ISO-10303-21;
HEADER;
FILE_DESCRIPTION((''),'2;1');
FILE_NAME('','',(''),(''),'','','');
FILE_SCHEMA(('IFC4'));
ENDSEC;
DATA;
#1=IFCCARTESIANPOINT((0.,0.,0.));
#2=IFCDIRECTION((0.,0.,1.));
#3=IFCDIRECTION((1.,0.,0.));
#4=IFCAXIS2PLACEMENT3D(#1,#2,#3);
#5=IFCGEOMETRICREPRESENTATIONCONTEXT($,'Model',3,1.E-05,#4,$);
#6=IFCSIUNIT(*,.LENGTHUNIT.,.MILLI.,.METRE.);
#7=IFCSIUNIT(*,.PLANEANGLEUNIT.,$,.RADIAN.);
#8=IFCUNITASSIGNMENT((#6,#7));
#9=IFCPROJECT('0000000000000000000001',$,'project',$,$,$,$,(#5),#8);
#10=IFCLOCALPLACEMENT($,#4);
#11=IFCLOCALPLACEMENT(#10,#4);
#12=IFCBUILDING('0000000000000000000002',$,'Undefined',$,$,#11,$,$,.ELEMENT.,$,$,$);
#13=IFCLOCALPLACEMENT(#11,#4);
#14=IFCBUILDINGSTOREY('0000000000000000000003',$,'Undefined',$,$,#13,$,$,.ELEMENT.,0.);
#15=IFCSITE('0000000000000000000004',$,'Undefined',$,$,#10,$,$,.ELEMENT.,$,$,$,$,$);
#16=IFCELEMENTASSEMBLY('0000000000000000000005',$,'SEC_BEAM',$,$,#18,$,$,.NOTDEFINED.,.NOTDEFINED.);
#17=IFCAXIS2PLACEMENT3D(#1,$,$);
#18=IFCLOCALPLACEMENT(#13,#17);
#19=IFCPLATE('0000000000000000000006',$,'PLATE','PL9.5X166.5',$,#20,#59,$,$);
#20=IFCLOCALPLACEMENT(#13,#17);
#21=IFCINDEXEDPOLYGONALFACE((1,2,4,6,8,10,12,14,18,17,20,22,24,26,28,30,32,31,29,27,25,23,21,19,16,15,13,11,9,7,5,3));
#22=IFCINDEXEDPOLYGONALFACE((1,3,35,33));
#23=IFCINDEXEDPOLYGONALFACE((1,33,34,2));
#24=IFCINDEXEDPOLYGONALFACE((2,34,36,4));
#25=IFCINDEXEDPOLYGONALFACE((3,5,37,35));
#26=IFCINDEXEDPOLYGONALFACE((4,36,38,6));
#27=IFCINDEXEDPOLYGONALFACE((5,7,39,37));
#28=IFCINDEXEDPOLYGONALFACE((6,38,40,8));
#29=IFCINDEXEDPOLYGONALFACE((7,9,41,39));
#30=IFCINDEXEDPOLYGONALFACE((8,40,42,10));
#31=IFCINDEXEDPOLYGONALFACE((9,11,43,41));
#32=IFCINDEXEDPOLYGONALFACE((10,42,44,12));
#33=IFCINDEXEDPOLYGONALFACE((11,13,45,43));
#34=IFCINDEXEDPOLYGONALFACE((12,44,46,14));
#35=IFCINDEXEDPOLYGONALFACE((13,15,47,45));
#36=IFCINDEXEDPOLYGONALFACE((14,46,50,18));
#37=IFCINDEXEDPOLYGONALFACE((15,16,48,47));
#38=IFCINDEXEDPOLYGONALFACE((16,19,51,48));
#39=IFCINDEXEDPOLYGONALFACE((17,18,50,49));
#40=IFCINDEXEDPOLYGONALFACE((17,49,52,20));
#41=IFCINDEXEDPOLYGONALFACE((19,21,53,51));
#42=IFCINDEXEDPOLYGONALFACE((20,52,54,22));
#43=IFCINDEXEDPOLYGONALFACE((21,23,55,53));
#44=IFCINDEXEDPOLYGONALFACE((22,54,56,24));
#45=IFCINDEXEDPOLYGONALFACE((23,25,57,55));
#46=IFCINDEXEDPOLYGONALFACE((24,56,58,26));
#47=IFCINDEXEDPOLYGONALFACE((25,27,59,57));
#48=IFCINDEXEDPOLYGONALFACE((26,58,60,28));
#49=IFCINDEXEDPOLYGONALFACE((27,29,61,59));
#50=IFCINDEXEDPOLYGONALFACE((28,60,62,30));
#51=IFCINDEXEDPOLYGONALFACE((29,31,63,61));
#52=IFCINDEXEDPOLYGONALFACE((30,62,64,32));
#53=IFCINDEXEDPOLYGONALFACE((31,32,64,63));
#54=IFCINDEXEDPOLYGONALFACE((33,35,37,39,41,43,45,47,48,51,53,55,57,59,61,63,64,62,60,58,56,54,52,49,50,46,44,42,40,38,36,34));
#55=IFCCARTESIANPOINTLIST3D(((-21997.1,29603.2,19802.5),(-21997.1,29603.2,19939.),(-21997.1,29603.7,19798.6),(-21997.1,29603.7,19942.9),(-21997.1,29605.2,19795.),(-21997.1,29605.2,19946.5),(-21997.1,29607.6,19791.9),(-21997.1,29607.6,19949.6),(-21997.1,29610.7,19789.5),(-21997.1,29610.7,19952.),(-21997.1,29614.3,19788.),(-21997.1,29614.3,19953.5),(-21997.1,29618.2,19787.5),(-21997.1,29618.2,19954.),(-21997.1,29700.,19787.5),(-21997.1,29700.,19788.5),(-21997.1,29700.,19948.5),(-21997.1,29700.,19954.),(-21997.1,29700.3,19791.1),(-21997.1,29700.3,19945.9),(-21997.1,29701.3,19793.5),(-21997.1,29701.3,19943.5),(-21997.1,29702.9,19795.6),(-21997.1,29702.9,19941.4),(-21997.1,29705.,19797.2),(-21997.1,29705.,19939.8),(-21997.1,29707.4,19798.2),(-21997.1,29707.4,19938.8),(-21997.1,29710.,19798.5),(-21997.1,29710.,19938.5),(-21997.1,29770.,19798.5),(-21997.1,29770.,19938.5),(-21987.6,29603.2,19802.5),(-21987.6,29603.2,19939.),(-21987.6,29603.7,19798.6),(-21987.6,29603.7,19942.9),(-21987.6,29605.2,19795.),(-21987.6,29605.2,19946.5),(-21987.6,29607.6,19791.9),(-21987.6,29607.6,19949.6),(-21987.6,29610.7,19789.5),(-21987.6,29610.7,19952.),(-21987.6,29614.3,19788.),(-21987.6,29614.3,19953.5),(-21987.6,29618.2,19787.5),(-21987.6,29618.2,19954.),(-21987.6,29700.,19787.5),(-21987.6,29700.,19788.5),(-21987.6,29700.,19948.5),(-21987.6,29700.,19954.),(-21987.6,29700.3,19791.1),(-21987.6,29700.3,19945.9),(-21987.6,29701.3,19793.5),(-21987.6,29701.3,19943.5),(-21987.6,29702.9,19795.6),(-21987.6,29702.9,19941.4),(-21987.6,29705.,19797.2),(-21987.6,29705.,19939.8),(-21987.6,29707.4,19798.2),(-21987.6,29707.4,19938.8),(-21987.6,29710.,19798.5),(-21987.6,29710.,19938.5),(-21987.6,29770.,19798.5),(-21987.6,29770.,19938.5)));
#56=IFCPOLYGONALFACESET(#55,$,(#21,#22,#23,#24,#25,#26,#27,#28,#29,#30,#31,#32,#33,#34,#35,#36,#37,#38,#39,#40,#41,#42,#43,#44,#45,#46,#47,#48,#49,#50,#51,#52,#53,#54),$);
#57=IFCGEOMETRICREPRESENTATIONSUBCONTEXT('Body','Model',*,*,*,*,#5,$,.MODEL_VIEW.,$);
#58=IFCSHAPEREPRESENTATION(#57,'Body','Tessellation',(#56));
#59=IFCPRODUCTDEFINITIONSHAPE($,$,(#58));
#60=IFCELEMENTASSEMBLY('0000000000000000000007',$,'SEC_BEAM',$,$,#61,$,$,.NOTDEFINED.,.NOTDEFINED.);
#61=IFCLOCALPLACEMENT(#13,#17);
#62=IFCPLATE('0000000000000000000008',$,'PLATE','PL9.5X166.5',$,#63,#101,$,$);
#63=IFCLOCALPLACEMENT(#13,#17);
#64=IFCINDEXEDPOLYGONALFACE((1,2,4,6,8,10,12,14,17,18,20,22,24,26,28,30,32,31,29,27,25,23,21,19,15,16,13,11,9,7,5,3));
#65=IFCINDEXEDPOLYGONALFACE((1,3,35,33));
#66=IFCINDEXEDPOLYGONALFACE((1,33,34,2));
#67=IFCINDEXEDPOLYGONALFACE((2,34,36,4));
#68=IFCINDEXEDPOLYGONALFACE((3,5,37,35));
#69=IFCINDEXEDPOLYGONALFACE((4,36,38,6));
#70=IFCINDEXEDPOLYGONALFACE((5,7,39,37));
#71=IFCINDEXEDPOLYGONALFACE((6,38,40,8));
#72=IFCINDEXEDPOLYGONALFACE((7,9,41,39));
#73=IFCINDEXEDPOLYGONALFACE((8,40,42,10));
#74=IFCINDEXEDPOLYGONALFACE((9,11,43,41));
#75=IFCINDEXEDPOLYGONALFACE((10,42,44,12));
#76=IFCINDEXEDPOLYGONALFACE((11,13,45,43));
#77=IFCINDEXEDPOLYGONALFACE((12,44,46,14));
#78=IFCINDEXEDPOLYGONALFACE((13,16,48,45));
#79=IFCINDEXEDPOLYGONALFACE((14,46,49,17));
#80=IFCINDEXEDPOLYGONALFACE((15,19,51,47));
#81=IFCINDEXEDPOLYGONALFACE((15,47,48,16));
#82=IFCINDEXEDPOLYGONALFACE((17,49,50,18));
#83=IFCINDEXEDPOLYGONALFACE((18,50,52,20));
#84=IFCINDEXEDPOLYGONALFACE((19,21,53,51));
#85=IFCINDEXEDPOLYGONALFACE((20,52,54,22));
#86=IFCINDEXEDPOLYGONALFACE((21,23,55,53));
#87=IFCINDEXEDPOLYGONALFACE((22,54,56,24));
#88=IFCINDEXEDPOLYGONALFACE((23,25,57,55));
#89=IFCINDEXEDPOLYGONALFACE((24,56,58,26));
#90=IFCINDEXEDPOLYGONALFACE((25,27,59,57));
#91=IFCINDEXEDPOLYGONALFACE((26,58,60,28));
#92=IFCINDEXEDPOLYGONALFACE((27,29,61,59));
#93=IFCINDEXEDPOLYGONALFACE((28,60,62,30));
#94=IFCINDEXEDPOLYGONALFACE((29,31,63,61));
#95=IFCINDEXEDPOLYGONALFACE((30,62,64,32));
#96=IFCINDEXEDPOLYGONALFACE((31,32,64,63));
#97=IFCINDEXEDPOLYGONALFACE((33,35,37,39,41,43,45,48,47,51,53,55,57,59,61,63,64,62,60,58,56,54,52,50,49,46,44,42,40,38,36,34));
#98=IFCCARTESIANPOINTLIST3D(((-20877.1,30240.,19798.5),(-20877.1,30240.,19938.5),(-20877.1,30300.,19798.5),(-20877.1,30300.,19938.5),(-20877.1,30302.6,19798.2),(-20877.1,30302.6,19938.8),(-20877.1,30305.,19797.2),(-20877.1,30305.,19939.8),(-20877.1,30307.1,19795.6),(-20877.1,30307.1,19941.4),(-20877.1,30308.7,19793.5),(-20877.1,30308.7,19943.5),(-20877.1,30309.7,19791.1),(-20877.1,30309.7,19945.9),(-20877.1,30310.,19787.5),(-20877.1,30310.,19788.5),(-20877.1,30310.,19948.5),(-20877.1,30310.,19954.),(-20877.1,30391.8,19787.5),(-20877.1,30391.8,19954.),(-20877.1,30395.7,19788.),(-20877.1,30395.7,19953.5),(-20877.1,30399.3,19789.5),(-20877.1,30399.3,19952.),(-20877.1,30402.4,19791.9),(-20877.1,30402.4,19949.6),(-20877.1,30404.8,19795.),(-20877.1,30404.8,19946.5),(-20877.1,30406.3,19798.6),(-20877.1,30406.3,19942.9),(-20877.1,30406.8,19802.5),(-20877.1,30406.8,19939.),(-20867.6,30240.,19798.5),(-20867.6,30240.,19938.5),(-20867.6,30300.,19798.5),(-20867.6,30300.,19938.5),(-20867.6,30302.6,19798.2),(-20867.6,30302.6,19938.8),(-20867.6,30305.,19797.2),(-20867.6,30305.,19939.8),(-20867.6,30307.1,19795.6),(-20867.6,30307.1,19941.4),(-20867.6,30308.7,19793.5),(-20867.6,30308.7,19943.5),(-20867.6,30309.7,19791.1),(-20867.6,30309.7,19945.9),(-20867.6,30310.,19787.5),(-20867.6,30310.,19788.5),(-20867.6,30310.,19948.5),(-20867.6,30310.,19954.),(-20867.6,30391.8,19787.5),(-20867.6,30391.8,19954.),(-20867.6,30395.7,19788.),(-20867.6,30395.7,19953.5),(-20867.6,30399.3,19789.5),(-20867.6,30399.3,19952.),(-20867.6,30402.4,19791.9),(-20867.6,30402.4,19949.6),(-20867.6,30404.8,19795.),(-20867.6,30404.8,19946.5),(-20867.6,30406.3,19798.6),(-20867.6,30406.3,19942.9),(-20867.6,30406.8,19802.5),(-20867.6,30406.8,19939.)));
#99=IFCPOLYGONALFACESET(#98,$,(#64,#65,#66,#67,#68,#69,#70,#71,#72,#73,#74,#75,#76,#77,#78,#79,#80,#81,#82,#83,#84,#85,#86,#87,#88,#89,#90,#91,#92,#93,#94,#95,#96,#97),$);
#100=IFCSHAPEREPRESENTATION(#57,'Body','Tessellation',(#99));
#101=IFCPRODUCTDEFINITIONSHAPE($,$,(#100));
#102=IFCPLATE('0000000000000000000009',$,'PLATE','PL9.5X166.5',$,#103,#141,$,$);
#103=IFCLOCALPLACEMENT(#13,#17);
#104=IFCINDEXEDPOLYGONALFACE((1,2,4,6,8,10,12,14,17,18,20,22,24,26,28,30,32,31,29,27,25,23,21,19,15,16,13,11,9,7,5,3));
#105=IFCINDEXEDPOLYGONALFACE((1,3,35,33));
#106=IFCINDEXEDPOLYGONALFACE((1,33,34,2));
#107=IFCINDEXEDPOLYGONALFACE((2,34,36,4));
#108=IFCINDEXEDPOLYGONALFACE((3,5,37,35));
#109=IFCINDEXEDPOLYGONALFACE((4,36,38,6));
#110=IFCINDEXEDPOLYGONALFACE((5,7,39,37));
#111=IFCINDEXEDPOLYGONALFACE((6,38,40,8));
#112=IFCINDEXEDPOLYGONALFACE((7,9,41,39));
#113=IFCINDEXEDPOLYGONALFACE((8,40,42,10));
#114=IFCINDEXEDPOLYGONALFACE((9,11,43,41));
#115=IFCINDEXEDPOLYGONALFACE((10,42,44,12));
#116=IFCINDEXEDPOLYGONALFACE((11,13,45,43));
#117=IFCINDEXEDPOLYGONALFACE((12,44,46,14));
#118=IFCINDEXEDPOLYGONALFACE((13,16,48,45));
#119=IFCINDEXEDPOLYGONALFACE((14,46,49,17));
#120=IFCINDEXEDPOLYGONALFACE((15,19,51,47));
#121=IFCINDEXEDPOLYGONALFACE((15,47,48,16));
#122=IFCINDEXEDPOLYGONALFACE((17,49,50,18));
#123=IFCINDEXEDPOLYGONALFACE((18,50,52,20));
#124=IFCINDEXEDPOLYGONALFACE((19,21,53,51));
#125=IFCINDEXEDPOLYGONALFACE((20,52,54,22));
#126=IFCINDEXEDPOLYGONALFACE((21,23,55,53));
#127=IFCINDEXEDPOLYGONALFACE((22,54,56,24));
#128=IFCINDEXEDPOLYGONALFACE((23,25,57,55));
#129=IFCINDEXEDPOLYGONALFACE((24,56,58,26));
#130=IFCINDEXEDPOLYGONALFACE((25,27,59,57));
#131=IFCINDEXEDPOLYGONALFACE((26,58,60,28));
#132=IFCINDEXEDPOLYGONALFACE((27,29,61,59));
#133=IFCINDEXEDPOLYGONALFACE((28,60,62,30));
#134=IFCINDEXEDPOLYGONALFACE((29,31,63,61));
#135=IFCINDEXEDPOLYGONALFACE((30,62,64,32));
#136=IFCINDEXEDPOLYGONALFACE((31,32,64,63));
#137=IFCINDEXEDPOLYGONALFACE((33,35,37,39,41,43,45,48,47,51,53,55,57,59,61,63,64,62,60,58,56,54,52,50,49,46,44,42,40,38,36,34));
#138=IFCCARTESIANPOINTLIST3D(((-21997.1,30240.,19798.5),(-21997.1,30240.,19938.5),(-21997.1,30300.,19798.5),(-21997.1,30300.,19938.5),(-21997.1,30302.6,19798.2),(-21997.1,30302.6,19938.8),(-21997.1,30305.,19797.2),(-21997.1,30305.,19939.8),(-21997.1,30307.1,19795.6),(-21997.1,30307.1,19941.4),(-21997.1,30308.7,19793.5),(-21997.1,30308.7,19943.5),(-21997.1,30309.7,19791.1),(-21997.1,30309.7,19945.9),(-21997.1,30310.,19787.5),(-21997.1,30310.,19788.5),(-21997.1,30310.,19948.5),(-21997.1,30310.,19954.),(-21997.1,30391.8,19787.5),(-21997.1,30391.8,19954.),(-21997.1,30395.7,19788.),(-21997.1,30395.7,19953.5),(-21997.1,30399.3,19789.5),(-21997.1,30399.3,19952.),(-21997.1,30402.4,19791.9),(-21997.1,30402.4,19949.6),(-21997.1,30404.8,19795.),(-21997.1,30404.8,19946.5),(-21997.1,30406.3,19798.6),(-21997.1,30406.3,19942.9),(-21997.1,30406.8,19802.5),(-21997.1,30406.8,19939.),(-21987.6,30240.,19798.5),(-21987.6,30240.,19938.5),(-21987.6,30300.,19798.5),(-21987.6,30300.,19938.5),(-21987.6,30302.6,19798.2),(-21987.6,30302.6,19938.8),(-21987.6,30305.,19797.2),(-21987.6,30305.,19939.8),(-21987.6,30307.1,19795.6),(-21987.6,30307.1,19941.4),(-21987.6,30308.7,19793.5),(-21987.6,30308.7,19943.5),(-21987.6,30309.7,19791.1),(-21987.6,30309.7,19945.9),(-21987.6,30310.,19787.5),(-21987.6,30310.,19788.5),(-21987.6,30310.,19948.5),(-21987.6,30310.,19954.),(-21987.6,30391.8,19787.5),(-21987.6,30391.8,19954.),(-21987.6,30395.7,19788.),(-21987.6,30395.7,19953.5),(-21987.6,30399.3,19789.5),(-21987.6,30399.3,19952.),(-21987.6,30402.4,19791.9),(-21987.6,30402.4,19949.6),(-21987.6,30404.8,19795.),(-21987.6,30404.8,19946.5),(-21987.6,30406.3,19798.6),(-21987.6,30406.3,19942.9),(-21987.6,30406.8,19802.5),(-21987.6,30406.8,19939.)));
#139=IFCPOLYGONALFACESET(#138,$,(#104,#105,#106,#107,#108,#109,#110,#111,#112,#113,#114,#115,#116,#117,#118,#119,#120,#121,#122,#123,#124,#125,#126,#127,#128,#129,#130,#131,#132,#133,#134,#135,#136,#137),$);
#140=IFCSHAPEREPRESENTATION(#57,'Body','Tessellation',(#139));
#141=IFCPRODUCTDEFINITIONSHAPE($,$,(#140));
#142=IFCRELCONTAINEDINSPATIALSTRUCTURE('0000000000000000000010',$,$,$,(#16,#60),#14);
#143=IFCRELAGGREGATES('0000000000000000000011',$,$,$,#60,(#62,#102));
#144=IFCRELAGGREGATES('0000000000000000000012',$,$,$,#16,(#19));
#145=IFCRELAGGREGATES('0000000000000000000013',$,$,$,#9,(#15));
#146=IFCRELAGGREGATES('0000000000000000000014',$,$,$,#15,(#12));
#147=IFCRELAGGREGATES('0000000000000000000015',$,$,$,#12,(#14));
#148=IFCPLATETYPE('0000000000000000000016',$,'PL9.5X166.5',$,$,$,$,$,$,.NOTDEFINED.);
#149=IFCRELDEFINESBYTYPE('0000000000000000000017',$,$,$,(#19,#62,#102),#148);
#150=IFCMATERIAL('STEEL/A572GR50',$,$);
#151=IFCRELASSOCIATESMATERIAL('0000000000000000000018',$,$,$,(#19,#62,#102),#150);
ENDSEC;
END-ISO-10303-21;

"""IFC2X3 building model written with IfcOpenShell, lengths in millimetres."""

from ifc_helpers import new_model, si_unit, frame, frame_2d, origin_with_axes, place, context, subcontext, project, spatial, polyline, circle_curve, parameter, trimmed, segment, composite_curve, outline, extrude, material, type_object, element, aggregate, save


model = new_model("IFC2X3")

# Units and contexts
model_context = context("Model", 3, precision=1e-05, world=origin_with_axes())
body_context = subcontext(model_context, "Body", "Model", "MODEL_VIEW")
ifc_project = project(units=[si_unit("LENGTHUNIT", "METRE", prefix="MILLI"), si_unit("PLANEANGLEUNIT", "RADIAN")], contexts=[model_context])

# Site, building, storey
site_placement = place(None, origin_with_axes())
site = spatial("IfcSite", under=ifc_project, at=site_placement, Name="Undefined", CompositionType="ELEMENT")
building_placement = place(site_placement, origin_with_axes())
building = spatial("IfcBuilding", under=site, at=building_placement, Name="Undefined", CompositionType="ELEMENT")
storey_placement = place(building_placement, origin_with_axes())
storey = spatial("IfcBuildingStorey", under=building, at=storey_placement, Name="Undefined", CompositionType="ELEMENT", Elevation=0.0)

# Shared definitions
ifc_material_1 = material(Name="STEEL/A572GR50")

# Element assemblies, plates
assembly_1_placement = place(storey_placement, origin_with_axes())
assembly_1 = element("IfcElementAssembly", 1, at=assembly_1_placement, inside=storey, Name="SEC_BEAM", AssemblyPlace="NOTDEFINED", PredefinedType="NOTDEFINED")
plate_type_1 = type_object("IfcPlateType", Name="PL9.5X166.5", PredefinedType="NOTDEFINED")
plate_1_placement = place(assembly_1_placement, frame((-21992.3, 29603.2, 19954.0), z_axis=(1.0, 0.0, 0.0), x_axis=(0.0, 0.0, -1.0)))
plate_1 = element("IfcPlate", 2, at=plate_1_placement, type_object=plate_type_1, material=ifc_material_1, Name="PLATE", Description="PL9.5X166.5", context=body_context, shape_type="SweptSolid", body=[
    extrude(outline(composite_curve([segment(trimmed(circle_curve(frame_2d((15.0, 15.0), x_axis=(-1.0, 0.0)), 15.0), [parameter(0.0)], [parameter(1.570796)], True, "PARAMETER"), True, "CONTINUOUS"), segment(polyline([(15.0, 0.0), (151.5, 0.0)]), True, "CONTINUOUS"), segment(trimmed(circle_curve(frame_2d((151.5, 15.0), x_axis=(0.0, -1.0)), 15.0), [parameter(0.0)], [parameter(1.570796)], True, "PARAMETER"), True, "CONTINUOUS"), segment(polyline([(166.5, 15.0), (166.5, 96.8), (165.5, 96.8)]), True, "CONTINUOUS"), segment(trimmed(circle_curve(frame_2d((165.5, 106.8), x_axis=(0.0, -1.0)), 10.0), [parameter(0.0)], [parameter(4.712389)], False, "PARAMETER"), True, "CONTINUOUS"), segment(polyline([(155.5, 106.8), (155.5, 166.8), (15.5, 166.8), (15.5, 106.8)]), True, "CONTINUOUS"), segment(trimmed(circle_curve(frame_2d((5.5, 106.8), x_axis=(1.0, 0.0)), 10.0), [parameter(0.0)], [parameter(4.712389)], False, "PARAMETER"), True, "CONTINUOUS"), segment(polyline([(5.5, 96.8), (0.0, 96.8), (0.0, 15.0)]), True, "CONTINUOUS")], self_intersect=True)), frame((0.0, 0.0, -4.8), z_axis=(0.0, 0.0, 1.0), x_axis=(1.0, 0.0, 0.0)), (0.0, 0.0, 1.0), 9.5),
])
assembly_2_placement = place(storey_placement, origin_with_axes())
assembly_2 = element("IfcElementAssembly", 3, at=assembly_2_placement, inside=storey, Name="SEC_BEAM", AssemblyPlace="NOTDEFINED", PredefinedType="NOTDEFINED")
plate_2_placement = place(assembly_2_placement, frame((-20872.3, 30406.8, 19954.0), z_axis=(-1.0, 0.0, 0.0), x_axis=(0.0, 0.0, -1.0)))
plate_2 = element("IfcPlate", 4, at=plate_2_placement, type_object=plate_type_1, material=ifc_material_1, Name="PLATE", Description="PL9.5X166.5", context=body_context, shape_type="SweptSolid", body=[
    extrude(outline(composite_curve([segment(trimmed(circle_curve(frame_2d((15.0, 15.0), x_axis=(-1.0, 0.0)), 15.0), [parameter(0.0)], [parameter(1.570796)], True, "PARAMETER"), True, "CONTINUOUS"), segment(polyline([(15.0, 0.0), (151.5, 0.0)]), True, "CONTINUOUS"), segment(trimmed(circle_curve(frame_2d((151.5, 15.0), x_axis=(0.0, -1.0)), 15.0), [parameter(0.0)], [parameter(1.570796)], True, "PARAMETER"), True, "CONTINUOUS"), segment(polyline([(166.5, 15.0), (166.5, 96.8), (165.5, 96.8)]), True, "CONTINUOUS"), segment(trimmed(circle_curve(frame_2d((165.5, 106.8), x_axis=(0.0, -1.0)), 10.0), [parameter(0.0)], [parameter(4.712389)], False, "PARAMETER"), True, "CONTINUOUS"), segment(polyline([(155.5, 106.8), (155.5, 166.8), (15.5, 166.8), (15.5, 106.8)]), True, "CONTINUOUS"), segment(trimmed(circle_curve(frame_2d((5.5, 106.8), x_axis=(1.0, 0.0)), 10.0), [parameter(0.0)], [parameter(4.712389)], False, "PARAMETER"), True, "CONTINUOUS"), segment(polyline([(5.5, 96.8), (0.0, 96.8), (0.0, 15.0)]), True, "CONTINUOUS")], self_intersect=True)), frame((0.0, 0.0, -4.8), z_axis=(0.0, 0.0, 1.0), x_axis=(1.0, 0.0, 0.0)), (0.0, 0.0, 1.0), 9.5),
])
plate_3_placement = place(assembly_2_placement, frame((-21992.3, 30406.8, 19954.0), z_axis=(-1.0, 0.0, 0.0), x_axis=(0.0, 0.0, -1.0)))
plate_3 = element("IfcPlate", 5, at=plate_3_placement, type_object=plate_type_1, material=ifc_material_1, Name="PLATE", Description="PL9.5X166.5", context=body_context, shape_type="SweptSolid", body=[
    extrude(outline(composite_curve([segment(trimmed(circle_curve(frame_2d((15.0, 15.0), x_axis=(-1.0, 0.0)), 15.0), [parameter(0.0)], [parameter(1.570796)], True, "PARAMETER"), True, "CONTINUOUS"), segment(polyline([(15.0, 0.0), (151.5, 0.0)]), True, "CONTINUOUS"), segment(trimmed(circle_curve(frame_2d((151.5, 15.0), x_axis=(0.0, -1.0)), 15.0), [parameter(0.0)], [parameter(1.570796)], True, "PARAMETER"), True, "CONTINUOUS"), segment(polyline([(166.5, 15.0), (166.5, 96.8), (165.5, 96.8)]), True, "CONTINUOUS"), segment(trimmed(circle_curve(frame_2d((165.5, 106.8), x_axis=(0.0, -1.0)), 10.0), [parameter(0.0)], [parameter(4.712389)], False, "PARAMETER"), True, "CONTINUOUS"), segment(polyline([(155.5, 106.8), (155.5, 166.8), (15.5, 166.8), (15.5, 106.8)]), True, "CONTINUOUS"), segment(trimmed(circle_curve(frame_2d((5.5, 106.8), x_axis=(1.0, 0.0)), 10.0), [parameter(0.0)], [parameter(4.712389)], False, "PARAMETER"), True, "CONTINUOUS"), segment(polyline([(5.5, 96.8), (0.0, 96.8), (0.0, 15.0)]), True, "CONTINUOUS")], self_intersect=True)), frame((0.0, 0.0, -4.8), z_axis=(0.0, 0.0, 1.0), x_axis=(1.0, 0.0, 0.0)), (0.0, 0.0, 1.0), 9.5),
])
aggregate(assembly_2, [plate_2, plate_3])

aggregate(assembly_1, [plate_1])

save(model, "model.ifc")
